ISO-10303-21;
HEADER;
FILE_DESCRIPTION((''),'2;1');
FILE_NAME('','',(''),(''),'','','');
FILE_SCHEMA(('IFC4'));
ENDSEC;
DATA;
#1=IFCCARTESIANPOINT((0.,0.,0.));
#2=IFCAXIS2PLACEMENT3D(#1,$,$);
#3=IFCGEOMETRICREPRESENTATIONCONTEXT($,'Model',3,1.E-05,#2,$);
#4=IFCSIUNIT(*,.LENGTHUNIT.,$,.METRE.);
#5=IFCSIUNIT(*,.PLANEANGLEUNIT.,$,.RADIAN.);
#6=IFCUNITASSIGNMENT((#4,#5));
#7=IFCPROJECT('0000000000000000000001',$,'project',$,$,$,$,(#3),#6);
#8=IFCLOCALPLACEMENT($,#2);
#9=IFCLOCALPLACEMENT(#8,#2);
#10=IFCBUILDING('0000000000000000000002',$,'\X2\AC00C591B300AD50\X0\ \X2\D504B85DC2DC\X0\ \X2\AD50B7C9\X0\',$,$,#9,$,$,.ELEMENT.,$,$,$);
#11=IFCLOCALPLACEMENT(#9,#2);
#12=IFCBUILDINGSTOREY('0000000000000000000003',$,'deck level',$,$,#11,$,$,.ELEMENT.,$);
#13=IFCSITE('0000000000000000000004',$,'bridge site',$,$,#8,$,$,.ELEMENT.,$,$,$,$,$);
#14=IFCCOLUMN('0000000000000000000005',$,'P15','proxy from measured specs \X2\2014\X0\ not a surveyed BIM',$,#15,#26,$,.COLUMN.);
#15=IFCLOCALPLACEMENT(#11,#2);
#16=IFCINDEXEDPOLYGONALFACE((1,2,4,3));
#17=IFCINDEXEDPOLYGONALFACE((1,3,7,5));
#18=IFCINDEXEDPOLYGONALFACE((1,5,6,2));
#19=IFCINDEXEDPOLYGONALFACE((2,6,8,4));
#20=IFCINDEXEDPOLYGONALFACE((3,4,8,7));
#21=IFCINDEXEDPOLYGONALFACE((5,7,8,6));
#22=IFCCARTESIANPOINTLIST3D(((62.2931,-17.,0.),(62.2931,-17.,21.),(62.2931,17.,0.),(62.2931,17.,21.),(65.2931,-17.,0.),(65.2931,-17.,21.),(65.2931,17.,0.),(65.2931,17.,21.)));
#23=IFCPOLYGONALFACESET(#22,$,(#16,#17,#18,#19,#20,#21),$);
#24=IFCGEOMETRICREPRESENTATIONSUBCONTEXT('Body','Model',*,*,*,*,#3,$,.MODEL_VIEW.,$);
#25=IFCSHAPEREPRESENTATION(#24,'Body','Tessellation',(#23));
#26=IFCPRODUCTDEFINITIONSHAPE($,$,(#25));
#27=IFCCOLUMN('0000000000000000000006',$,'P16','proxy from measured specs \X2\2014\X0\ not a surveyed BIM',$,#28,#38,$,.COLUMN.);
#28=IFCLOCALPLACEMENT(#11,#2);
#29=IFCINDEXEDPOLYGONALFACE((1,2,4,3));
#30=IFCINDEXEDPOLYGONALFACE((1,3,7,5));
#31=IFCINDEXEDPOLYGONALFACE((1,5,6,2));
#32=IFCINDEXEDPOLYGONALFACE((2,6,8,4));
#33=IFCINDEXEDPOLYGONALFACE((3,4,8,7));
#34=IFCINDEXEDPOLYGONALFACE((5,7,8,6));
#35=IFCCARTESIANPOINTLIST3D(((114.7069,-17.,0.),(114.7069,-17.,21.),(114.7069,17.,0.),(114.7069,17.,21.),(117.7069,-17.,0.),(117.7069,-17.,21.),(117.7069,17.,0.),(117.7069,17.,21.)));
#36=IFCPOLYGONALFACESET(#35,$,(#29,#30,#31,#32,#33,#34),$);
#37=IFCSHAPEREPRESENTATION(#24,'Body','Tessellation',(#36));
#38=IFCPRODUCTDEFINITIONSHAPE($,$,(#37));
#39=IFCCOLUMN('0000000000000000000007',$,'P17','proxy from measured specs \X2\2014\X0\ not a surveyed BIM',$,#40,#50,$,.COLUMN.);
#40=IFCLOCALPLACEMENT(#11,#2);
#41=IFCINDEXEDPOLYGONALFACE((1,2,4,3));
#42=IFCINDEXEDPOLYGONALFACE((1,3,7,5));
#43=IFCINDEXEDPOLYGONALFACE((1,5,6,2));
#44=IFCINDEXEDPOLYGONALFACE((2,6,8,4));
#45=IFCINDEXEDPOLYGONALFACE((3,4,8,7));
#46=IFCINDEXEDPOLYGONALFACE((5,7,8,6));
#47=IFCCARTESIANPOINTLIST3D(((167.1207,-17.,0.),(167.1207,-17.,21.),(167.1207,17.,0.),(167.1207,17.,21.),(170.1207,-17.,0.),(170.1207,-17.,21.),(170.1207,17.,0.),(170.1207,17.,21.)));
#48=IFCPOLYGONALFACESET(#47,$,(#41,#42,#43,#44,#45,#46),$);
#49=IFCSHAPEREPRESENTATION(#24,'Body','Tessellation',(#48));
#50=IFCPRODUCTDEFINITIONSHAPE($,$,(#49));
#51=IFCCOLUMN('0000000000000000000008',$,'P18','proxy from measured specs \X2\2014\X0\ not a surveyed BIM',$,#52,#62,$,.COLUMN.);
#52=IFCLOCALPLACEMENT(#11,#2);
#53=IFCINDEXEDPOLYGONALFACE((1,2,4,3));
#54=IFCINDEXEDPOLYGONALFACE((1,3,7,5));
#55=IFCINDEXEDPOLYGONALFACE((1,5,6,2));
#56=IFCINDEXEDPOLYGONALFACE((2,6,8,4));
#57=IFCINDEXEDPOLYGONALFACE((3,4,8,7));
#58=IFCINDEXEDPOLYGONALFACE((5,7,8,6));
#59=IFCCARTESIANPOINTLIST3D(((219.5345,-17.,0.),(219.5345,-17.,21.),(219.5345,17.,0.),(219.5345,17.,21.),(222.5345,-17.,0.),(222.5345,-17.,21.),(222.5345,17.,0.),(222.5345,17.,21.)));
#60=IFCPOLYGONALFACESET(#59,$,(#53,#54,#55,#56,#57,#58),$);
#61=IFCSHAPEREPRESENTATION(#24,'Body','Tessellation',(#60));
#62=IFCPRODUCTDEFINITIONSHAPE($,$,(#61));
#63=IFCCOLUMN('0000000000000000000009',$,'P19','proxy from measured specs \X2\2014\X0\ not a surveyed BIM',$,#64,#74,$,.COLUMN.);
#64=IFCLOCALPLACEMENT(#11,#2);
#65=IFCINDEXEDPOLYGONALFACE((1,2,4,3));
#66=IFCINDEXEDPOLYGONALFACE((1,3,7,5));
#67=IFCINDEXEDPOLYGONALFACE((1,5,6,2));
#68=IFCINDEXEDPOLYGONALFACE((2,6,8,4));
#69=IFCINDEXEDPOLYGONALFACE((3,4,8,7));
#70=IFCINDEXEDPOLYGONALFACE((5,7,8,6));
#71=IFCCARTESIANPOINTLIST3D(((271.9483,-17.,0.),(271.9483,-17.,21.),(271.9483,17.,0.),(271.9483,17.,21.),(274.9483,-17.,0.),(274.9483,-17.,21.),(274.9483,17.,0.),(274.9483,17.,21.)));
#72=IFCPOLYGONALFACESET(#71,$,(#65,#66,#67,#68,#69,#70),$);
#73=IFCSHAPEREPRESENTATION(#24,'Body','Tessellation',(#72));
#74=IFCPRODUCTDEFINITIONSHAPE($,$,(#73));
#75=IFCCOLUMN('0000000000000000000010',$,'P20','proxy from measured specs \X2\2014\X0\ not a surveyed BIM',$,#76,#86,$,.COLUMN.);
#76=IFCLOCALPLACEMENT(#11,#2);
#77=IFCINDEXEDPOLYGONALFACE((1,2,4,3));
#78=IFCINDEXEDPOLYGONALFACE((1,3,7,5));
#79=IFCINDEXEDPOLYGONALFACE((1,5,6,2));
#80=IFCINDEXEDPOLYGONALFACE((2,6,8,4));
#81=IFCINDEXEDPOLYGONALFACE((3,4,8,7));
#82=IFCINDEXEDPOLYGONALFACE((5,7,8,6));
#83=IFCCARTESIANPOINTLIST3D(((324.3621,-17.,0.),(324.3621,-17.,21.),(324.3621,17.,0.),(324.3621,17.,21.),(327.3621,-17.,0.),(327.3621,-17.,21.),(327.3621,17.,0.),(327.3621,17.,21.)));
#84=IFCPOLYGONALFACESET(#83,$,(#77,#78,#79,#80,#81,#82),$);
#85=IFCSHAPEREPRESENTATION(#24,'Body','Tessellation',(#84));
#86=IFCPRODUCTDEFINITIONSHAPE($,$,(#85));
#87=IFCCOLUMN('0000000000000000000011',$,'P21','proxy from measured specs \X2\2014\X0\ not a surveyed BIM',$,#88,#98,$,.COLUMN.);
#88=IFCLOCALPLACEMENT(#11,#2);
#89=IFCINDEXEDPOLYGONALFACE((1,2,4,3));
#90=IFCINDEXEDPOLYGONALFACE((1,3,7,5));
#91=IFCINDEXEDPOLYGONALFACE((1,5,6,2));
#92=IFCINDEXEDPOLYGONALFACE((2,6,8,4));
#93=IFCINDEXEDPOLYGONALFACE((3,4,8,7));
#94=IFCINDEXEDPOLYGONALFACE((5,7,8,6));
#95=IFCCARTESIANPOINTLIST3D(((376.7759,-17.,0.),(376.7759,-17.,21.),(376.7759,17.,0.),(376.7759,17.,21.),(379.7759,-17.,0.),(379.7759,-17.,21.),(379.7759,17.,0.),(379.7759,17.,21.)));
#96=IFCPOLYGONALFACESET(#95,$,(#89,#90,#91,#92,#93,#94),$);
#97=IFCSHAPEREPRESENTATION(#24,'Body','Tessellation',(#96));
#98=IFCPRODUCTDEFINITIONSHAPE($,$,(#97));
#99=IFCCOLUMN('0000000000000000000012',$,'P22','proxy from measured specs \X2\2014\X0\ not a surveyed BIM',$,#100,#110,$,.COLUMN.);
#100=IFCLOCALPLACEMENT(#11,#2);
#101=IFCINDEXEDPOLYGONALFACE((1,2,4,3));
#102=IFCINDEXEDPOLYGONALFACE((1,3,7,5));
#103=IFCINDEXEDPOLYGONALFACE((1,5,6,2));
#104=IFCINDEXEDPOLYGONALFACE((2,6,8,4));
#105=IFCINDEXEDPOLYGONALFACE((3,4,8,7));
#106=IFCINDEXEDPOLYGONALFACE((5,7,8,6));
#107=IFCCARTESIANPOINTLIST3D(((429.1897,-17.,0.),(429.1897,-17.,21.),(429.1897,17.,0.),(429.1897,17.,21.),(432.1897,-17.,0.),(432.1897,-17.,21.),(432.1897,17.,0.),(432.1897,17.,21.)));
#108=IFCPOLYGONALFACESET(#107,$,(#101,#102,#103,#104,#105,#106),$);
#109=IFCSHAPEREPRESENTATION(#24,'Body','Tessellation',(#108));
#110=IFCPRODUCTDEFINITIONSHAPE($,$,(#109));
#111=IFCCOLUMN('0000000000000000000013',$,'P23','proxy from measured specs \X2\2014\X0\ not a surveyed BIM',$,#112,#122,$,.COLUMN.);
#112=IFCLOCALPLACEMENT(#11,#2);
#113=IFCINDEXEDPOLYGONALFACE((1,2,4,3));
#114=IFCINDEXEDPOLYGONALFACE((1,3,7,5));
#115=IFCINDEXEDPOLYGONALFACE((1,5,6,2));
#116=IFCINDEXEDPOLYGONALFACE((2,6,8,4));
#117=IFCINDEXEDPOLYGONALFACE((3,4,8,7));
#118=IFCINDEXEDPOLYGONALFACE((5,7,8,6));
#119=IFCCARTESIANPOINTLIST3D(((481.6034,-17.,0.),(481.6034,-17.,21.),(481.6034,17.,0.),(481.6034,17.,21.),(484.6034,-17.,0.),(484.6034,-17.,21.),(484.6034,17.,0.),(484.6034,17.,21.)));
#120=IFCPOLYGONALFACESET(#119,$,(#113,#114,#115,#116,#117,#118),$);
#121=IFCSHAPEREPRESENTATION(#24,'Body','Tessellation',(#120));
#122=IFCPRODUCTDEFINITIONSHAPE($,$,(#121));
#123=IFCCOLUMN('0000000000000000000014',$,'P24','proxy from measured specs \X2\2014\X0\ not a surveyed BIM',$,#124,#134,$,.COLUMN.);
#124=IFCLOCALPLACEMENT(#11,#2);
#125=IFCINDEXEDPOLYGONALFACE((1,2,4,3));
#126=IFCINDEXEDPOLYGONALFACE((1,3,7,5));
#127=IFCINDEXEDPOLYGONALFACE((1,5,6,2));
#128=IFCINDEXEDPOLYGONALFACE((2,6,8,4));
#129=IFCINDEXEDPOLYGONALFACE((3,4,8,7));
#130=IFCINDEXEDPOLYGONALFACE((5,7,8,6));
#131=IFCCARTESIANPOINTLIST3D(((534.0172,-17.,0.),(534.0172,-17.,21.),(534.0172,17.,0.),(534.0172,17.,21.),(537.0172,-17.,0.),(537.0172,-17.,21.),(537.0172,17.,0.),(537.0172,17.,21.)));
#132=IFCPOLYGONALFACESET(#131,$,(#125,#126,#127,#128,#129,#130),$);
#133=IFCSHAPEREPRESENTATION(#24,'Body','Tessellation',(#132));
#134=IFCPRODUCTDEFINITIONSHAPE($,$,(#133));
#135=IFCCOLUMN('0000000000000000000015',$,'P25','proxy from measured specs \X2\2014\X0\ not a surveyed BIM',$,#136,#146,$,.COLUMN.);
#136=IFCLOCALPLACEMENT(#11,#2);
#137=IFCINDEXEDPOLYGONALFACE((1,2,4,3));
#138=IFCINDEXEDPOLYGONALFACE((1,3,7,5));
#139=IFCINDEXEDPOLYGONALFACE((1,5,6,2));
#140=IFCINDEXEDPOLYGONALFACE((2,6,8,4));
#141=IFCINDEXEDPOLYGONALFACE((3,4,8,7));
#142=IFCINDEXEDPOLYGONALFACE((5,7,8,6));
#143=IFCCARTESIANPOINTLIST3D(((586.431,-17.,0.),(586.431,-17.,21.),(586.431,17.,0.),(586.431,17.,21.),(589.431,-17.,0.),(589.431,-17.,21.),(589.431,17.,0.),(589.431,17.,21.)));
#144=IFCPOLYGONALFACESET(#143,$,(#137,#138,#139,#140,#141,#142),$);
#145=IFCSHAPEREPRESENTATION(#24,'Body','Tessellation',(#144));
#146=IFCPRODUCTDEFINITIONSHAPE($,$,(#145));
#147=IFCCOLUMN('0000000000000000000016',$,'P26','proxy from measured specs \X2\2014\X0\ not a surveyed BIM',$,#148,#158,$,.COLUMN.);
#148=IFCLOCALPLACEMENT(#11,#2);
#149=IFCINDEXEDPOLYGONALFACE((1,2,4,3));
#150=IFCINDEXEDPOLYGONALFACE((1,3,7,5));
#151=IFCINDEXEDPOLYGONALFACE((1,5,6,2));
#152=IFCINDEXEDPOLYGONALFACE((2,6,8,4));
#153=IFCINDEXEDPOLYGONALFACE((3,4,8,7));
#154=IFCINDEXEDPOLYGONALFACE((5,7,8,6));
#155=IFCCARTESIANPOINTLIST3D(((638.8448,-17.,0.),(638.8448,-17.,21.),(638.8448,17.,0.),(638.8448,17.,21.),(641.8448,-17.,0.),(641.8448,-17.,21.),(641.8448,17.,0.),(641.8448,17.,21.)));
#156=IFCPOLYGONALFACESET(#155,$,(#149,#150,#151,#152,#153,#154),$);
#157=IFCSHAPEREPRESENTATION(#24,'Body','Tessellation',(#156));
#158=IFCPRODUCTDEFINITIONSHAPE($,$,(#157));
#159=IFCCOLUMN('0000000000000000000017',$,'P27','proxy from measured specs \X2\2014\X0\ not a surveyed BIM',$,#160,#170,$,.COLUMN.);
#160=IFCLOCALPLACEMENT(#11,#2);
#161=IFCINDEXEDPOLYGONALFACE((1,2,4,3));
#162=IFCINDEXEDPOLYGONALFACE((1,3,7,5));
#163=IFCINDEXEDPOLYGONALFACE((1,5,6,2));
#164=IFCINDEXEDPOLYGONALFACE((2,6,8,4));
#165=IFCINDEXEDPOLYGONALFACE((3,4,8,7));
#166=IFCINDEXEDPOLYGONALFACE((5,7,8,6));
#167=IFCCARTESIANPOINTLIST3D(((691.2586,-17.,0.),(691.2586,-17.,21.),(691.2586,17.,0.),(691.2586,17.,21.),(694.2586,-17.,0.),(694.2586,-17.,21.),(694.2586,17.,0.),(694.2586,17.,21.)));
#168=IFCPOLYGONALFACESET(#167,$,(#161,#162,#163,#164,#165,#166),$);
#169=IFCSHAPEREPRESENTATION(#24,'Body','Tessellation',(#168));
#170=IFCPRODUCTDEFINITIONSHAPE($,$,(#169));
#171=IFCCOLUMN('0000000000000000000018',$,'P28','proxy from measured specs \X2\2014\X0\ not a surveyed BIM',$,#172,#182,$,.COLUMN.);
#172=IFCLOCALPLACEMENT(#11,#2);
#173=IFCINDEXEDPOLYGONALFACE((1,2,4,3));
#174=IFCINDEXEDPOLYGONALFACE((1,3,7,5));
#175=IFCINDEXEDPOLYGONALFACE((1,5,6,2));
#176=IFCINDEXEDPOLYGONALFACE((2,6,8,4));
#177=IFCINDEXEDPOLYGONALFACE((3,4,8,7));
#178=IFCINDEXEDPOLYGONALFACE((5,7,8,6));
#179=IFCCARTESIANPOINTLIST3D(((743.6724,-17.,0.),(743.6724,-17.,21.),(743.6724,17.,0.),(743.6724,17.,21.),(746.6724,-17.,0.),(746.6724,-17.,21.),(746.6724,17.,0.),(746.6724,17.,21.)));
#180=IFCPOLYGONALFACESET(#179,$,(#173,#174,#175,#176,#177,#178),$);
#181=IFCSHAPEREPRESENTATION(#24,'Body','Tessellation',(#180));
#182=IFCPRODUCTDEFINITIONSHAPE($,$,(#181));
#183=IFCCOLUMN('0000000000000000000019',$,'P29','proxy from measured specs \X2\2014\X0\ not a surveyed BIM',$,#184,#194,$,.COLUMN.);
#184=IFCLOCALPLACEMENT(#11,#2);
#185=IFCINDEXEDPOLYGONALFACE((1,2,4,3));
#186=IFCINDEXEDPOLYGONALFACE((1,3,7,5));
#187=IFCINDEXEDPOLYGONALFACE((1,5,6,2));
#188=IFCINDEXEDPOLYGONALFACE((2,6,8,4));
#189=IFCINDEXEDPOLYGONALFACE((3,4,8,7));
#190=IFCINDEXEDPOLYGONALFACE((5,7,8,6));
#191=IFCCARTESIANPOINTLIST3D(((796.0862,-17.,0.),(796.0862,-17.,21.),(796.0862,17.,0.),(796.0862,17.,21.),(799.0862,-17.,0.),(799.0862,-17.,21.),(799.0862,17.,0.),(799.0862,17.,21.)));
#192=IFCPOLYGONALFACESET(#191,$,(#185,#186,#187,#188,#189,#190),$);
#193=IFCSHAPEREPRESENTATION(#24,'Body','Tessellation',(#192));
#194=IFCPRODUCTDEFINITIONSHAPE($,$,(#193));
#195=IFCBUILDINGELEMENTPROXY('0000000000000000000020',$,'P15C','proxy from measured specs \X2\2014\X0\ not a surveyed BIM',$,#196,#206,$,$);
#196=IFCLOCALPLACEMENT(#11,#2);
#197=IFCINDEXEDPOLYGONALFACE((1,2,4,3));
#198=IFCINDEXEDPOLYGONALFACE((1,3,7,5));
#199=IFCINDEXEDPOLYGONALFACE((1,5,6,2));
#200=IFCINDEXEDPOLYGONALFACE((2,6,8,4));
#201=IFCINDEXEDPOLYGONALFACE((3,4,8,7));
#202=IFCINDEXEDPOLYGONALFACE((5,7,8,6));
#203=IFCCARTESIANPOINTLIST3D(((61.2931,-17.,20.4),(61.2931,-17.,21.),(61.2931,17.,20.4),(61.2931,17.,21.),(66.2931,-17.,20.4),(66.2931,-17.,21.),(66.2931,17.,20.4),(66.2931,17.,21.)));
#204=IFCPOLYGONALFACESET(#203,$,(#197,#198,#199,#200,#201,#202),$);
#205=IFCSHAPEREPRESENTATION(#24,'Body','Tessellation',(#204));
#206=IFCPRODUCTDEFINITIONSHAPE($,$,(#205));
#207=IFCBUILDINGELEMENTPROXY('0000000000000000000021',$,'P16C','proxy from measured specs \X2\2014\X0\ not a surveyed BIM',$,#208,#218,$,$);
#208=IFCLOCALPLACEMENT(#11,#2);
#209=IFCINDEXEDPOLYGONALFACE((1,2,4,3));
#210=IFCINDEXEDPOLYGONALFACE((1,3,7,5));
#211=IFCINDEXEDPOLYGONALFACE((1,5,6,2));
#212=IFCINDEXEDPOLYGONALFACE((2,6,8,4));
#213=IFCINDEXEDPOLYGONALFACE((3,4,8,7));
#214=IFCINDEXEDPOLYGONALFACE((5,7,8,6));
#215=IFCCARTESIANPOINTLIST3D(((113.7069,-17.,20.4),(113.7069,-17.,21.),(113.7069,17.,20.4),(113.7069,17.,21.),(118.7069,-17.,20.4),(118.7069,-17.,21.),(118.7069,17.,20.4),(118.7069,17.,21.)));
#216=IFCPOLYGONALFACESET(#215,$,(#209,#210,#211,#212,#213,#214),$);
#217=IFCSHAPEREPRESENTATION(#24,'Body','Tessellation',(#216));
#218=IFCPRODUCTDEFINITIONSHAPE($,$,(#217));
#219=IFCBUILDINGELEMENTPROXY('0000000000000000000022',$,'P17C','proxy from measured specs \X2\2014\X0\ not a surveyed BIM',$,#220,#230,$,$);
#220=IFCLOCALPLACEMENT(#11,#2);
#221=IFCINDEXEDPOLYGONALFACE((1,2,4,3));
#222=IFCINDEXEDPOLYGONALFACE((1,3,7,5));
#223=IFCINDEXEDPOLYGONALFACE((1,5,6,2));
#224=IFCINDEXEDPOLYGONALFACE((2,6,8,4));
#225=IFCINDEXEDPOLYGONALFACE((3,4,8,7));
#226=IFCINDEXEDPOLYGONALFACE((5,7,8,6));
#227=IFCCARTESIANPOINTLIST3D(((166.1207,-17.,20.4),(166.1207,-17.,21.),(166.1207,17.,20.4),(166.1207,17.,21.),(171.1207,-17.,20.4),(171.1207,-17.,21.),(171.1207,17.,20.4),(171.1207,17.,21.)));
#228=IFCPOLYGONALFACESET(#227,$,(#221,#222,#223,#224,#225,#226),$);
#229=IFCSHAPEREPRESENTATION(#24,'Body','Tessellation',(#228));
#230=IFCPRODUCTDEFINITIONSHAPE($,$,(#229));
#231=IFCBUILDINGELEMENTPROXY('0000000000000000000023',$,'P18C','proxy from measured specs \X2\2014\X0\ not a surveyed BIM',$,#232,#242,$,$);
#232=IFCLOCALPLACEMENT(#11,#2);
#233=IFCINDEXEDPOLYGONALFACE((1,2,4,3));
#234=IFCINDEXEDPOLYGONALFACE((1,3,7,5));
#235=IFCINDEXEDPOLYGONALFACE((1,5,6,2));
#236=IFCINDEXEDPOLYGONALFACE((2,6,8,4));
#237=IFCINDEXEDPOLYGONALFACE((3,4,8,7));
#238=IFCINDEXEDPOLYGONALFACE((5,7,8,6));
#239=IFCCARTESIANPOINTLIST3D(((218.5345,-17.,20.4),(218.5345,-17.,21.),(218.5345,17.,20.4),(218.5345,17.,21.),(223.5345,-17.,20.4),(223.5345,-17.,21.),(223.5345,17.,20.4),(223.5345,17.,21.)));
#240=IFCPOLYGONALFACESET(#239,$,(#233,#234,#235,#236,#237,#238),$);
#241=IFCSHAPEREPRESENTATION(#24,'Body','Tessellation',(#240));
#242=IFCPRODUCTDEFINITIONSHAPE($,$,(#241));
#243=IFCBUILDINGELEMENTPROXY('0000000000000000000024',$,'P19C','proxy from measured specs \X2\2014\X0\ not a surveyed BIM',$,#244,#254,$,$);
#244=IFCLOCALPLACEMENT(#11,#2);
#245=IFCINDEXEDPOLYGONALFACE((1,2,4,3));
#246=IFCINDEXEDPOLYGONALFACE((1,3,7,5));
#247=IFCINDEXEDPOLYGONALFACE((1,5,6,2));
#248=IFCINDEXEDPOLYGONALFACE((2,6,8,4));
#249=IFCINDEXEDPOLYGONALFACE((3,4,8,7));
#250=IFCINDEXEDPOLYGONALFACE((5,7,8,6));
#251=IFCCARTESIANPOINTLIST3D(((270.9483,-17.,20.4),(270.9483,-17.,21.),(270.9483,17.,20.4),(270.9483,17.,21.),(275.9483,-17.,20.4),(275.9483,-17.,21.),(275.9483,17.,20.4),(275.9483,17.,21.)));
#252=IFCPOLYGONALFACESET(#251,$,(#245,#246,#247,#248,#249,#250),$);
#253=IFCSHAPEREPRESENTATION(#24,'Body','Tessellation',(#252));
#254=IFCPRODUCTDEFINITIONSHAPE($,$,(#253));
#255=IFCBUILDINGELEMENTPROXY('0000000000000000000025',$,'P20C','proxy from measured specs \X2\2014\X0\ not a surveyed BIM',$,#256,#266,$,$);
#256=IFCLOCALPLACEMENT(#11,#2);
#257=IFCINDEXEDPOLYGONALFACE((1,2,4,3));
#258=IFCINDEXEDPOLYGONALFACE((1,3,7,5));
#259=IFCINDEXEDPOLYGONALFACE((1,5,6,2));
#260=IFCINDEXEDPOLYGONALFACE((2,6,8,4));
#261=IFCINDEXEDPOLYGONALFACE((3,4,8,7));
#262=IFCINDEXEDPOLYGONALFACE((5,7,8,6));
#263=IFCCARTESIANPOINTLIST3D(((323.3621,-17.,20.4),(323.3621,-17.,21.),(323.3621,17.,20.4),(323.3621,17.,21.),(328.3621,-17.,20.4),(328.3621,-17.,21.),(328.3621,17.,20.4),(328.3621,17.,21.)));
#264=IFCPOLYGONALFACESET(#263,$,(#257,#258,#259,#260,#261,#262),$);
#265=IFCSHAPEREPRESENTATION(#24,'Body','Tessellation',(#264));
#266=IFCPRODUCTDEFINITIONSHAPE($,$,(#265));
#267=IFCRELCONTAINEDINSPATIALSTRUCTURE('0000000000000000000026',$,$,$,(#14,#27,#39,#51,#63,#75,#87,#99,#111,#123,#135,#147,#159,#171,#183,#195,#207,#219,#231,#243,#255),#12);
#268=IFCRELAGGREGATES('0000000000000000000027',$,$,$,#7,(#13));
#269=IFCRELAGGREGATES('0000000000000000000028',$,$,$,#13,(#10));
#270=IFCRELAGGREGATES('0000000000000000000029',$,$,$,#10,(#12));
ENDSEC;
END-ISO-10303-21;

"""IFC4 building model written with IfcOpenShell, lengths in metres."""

from ifc_helpers import new_model, si_unit, frame, origin, origin_2d, place, context, subcontext, project, spatial, rectangle, extrude, element, save


model = new_model("IFC4")

# Units and contexts
model_context = context("Model", 3, precision=1e-05, world=origin())
body_context = subcontext(model_context, "Body", "Model", "MODEL_VIEW")
ifc_project = project(units=[si_unit("LENGTHUNIT", "METRE"), si_unit("PLANEANGLEUNIT", "RADIAN")], contexts=[model_context])

# Site, building, storey
site_placement = place(None, origin())
site = spatial("IfcSite", under=ifc_project, at=site_placement, Name="bridge site", CompositionType="ELEMENT")
building_placement = place(site_placement, origin())
building = spatial("IfcBuilding", under=site, at=building_placement, Name="가양대교 프록시 교량", CompositionType="ELEMENT")
storey_placement = place(building_placement, origin())
storey = spatial("IfcBuildingStorey", under=building, at=storey_placement, Name="deck level", CompositionType="ELEMENT")

# Columns
for number, where, name in (
    (1, (63.7931, 0.0, 0.0), "P15"),
    (2, (116.2069, 0.0, 0.0), "P16"),
    (3, (168.6207, 0.0, 0.0), "P17"),
    (4, (221.0345, 0.0, 0.0), "P18"),
    (5, (273.4483, 0.0, 0.0), "P19"),
    (6, (325.8621, 0.0, 0.0), "P20"),
    (7, (378.2759, 0.0, 0.0), "P21"),
    (8, (430.6897, 0.0, 0.0), "P22"),
    (9, (483.1034, 0.0, 0.0), "P23"),
    (10, (535.5172, 0.0, 0.0), "P24"),
    (11, (587.931, 0.0, 0.0), "P25"),
    (12, (640.3448, 0.0, 0.0), "P26"),
    (13, (692.7586, 0.0, 0.0), "P27"),
    (14, (745.1724, 0.0, 0.0), "P28"),
    (15, (797.5862, 0.0, 0.0), "P29"),
):
    element("IfcColumn", number, at=place(storey_placement, frame(where)), inside=storey, Name=name, Description="proxy from measured specs — not a surveyed BIM", PredefinedType="COLUMN", context=body_context, shape_type="SweptSolid", body=[
        extrude(rectangle(XDim=3.0, YDim=34.0, at=origin_2d()), origin(), (0.0, 0.0, 1.0), 21.0),
    ])

# Building element proxies
for number, where, name in (
    (16, (63.7931, 0.0, 20.4), "P15C"),
    (17, (116.2069, 0.0, 20.4), "P16C"),
    (18, (168.6207, 0.0, 20.4), "P17C"),
    (19, (221.0345, 0.0, 20.4), "P18C"),
    (20, (273.4483, 0.0, 20.4), "P19C"),
    (21, (325.8621, 0.0, 20.4), "P20C"),
):
    element("IfcBuildingElementProxy", number, at=place(storey_placement, frame(where)), inside=storey, Name=name, Description="proxy from measured specs — not a surveyed BIM", context=body_context, shape_type="SweptSolid", body=[
        extrude(rectangle(XDim=5.0, YDim=34.0, at=origin_2d()), origin(), (0.0, 0.0, 1.0), 0.6),
    ])

save(model, "model.ifc")
